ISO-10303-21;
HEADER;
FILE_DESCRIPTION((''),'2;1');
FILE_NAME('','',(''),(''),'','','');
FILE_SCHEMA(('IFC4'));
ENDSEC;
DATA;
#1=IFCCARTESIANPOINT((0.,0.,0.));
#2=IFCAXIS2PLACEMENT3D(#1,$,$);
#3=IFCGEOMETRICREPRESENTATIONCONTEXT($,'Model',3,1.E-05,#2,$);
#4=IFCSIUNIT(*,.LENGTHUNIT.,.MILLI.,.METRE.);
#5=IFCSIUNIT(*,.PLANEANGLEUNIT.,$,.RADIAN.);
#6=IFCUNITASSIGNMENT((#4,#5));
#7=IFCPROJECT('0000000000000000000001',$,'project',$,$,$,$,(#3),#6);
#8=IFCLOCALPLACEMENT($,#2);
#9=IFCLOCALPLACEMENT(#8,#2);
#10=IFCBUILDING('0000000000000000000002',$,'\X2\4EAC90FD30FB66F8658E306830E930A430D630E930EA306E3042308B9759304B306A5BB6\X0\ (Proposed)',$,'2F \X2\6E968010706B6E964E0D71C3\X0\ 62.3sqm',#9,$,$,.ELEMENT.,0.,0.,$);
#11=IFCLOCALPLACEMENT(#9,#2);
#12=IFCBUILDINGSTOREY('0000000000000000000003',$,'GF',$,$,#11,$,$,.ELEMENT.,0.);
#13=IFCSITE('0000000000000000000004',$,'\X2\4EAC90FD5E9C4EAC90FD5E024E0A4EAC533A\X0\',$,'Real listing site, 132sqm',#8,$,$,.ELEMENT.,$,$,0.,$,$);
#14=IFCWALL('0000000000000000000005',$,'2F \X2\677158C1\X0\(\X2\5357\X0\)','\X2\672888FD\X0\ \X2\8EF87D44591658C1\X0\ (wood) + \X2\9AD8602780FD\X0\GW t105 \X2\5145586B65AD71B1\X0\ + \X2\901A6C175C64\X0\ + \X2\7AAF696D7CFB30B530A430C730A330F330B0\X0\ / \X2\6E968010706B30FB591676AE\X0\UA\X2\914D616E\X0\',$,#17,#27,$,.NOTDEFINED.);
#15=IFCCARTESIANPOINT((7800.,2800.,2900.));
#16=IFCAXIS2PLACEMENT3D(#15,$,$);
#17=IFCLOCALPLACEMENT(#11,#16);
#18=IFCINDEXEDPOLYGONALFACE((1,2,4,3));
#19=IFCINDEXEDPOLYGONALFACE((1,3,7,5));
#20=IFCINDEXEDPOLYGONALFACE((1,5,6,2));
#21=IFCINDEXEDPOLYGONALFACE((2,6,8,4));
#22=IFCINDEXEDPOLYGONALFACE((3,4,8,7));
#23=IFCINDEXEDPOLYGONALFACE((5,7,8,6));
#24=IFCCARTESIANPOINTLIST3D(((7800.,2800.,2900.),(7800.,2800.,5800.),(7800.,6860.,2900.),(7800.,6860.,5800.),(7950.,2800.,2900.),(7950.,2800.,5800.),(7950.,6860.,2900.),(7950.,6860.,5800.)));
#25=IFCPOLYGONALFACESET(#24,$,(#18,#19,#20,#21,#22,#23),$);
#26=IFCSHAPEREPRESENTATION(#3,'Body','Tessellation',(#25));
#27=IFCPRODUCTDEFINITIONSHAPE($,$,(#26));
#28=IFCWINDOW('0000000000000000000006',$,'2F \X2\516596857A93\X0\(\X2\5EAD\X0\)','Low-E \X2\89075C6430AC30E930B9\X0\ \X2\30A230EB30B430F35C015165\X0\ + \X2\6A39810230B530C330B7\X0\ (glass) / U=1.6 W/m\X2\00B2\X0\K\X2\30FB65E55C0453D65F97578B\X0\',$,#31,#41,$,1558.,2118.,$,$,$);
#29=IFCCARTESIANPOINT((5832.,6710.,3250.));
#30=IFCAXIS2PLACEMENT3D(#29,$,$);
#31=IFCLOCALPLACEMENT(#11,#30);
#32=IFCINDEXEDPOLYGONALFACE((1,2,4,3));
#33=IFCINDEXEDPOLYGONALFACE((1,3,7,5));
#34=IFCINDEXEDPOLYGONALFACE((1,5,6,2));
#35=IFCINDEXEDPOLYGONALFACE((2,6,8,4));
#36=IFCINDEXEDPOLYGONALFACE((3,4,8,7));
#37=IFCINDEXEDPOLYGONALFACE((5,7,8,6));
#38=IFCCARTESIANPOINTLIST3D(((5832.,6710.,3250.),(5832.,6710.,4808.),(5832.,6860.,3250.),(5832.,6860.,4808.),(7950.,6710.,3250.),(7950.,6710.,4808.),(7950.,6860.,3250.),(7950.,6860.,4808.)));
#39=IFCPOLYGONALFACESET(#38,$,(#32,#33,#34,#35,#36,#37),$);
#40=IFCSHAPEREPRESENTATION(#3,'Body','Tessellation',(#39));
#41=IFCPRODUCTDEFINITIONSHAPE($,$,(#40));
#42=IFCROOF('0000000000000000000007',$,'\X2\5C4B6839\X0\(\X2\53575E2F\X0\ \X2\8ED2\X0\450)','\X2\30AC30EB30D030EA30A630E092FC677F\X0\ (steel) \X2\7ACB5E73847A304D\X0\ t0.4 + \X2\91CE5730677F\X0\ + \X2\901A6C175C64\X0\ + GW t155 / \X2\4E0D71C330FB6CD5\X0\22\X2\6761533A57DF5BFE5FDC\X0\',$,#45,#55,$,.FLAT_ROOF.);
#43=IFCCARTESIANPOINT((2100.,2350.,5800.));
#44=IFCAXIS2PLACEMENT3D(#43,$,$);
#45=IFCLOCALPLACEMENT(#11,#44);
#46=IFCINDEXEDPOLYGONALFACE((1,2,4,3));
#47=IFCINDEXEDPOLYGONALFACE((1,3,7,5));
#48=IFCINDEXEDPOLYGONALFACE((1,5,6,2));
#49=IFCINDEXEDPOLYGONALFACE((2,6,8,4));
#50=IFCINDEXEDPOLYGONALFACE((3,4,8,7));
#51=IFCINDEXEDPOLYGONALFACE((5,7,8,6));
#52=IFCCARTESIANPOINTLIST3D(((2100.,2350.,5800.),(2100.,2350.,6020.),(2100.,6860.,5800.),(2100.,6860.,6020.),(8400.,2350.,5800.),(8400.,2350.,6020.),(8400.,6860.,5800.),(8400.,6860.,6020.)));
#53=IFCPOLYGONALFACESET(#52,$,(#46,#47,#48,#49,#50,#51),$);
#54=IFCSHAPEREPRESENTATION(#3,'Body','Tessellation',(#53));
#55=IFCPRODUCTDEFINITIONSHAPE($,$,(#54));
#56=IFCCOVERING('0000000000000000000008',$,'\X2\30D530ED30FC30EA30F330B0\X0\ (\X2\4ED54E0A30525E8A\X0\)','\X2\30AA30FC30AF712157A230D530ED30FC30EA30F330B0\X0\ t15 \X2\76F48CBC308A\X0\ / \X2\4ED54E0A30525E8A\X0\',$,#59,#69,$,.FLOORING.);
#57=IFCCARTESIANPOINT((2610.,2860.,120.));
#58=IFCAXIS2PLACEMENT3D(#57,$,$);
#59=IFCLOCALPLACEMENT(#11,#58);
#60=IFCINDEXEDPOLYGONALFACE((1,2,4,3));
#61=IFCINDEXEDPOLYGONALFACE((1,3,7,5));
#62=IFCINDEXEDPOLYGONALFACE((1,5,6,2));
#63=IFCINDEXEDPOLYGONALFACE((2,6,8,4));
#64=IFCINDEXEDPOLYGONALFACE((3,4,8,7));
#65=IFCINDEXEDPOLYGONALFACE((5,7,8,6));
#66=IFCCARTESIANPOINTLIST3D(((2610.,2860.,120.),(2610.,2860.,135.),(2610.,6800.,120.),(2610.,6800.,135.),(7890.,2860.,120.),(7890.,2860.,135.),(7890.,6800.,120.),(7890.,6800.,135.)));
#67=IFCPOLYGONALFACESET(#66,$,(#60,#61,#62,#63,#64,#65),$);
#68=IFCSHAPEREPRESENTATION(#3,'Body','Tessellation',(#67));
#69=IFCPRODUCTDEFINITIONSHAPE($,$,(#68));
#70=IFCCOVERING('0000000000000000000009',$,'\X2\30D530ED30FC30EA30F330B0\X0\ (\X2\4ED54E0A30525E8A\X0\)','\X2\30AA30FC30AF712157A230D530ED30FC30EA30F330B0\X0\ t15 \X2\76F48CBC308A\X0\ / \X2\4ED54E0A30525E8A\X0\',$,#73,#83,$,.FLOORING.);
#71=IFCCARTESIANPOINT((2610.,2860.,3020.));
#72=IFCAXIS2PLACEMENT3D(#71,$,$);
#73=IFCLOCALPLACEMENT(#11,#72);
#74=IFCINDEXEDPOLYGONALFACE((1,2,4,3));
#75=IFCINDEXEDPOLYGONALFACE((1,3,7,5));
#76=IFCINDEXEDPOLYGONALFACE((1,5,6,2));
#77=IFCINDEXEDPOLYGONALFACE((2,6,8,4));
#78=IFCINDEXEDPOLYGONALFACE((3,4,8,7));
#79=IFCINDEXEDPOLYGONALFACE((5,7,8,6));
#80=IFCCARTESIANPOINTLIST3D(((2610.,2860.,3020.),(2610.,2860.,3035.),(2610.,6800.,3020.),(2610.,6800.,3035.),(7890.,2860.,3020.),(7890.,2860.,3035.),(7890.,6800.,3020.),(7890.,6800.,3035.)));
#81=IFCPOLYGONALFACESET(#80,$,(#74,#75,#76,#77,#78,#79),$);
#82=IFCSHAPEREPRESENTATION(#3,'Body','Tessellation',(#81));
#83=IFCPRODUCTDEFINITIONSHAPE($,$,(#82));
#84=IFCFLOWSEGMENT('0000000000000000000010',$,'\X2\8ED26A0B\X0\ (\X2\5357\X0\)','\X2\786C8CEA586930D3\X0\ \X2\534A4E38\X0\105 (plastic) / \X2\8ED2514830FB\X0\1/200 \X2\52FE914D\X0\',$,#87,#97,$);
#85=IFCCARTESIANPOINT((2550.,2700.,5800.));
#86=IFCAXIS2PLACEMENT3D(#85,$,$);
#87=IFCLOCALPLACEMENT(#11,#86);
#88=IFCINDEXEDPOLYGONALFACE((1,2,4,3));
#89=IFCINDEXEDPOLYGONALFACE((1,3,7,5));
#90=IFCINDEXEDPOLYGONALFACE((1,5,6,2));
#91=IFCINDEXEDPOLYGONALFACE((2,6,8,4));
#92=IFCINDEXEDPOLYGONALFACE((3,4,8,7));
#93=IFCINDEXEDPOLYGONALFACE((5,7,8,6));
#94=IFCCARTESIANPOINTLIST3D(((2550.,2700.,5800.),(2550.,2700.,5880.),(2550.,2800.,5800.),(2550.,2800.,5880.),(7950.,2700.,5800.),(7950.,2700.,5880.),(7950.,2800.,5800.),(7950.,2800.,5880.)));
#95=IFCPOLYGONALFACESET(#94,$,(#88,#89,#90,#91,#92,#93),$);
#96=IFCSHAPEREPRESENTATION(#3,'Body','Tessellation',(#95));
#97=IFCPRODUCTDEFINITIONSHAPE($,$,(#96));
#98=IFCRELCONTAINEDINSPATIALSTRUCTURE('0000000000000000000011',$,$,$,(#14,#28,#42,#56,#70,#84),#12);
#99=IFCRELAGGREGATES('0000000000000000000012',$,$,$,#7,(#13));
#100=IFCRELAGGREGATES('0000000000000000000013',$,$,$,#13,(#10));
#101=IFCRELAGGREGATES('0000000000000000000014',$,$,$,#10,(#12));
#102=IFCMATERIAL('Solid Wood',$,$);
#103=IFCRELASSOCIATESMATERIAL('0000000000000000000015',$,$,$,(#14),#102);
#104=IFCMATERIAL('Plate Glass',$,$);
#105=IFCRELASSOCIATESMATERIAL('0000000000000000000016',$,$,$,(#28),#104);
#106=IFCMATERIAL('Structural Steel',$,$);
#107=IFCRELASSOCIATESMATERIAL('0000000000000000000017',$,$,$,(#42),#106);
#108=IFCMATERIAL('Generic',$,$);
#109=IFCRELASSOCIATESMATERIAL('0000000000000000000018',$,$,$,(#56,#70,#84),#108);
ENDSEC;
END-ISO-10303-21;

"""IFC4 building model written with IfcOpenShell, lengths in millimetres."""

from ifc_helpers import new_model, si_unit, frame, frame_2d, origin, place, context, project, spatial, rectangle, extrude, material, element, fill, save


model = new_model("IFC4")

# Units and contexts
model_context = context("Model", 3, precision=1e-05, world=origin())
ifc_project = project(units=[si_unit("LENGTHUNIT", "METRE", prefix="MILLI"), si_unit("PLANEANGLEUNIT", "RADIAN")], contexts=[model_context])

# Site, building, storey
site_placement = place(None, origin())
site = spatial("IfcSite", under=ifc_project, at=site_placement, Name="京都府京都市上京区", ObjectType="Real listing site, 132sqm", CompositionType="ELEMENT", RefElevation=0.0)
building_placement = place(site_placement, origin())
building = spatial("IfcBuilding", under=site, at=building_placement, Name="京都・書斎とライブラリのある静かな家 (Proposed)", ObjectType="2F 準耐火準不燃 62.3sqm", CompositionType="ELEMENT", ElevationOfRefHeight=0.0, ElevationOfTerrain=0.0)
storey_placement = place(building_placement, origin())
storey = spatial("IfcBuildingStorey", under=building, at=storey_placement, Name="GF", CompositionType="ELEMENT", Elevation=0.0)

# Shared definitions
ifc_material_1 = material(Name="Solid Wood")

# Wall, opening, window
ifc_material_2 = material(Name="Plate Glass")
wall_1_placement = place(storey_placement, frame((7800.0, 2800.0, 2900.0)))
wall_1 = element("IfcWall", 1, at=wall_1_placement, inside=storey, material=ifc_material_1, Name="2F 東壁(南)", Description="木製 軸組外壁 (wood) + 高性能GW t105 充填断熱 + 通気層 + 窯業系サイディング / 準耐火・外皮UA配慮", PredefinedType="NOTDEFINED", context=model_context, shape_type="SweptSolid", body=[
    extrude(rectangle(XDim=150.0, YDim=4060.0, at=frame_2d((75.0, 2030.0))), frame((7800.0, 2800.0, 2900.0)), (0.0, 0.0, 1.0), 2900.0),
])
opening_1_placement = place(storey_placement, frame((5832.0, 6710.0, 3250.0)))
opening_1 = element("IfcOpeningElement", 2, at=opening_1_placement, cuts=wall_1, PredefinedType="NOTDEFINED", context=model_context, shape_type="SweptSolid", body=[
    extrude(rectangle(XDim=2118.0, YDim=150.0, at=frame_2d((1059.0, 75.0))), frame((5832.0, 6710.0, 3250.0)), (0.0, 0.0, 1.0), 1558.0),
])
window_1_placement = place(storey_placement, frame((5832.0, 6710.0, 3250.0)))
window_1 = element("IfcWindow", 3, at=window_1_placement, inside=storey, material=ifc_material_2, Name="2F 入隅窓(庭)", Description="Low-E 複層ガラス アルゴン封入 + 樹脂サッシ (glass) / U=1.6 W/m²K・日射取得型", OverallHeight=1558.0, OverallWidth=2118.0, context=model_context, shape_type="SweptSolid", body=[
    extrude(rectangle(XDim=2118.0, YDim=150.0, at=frame_2d((1059.0, 75.0))), frame((5832.0, 6710.0, 3250.0)), (0.0, 0.0, 1.0), 1558.0),
])
fill(opening_1, window_1)

# Roof
ifc_material_3 = material(Name="Structural Steel")
for number, where, name in (
    (4, (2100.0, 2350.0, 5800.0), "屋根(南帯 軒450)"),
):
    element("IfcRoof", number, at=place(storey_placement, frame(where)), inside=storey, material=ifc_material_3, Name=name, Description="ガルバリウム鋼板 (steel) 立平葺き t0.4 + 野地板 + 通気層 + GW t155 / 不燃・法22条区域対応", PredefinedType="FLAT_ROOF", context=model_context, shape_type="SweptSolid", body=[
        extrude(rectangle(XDim=6300.0, YDim=4510.0, at=frame_2d((3150.0, 2255.0))), frame((2100.0, 2350.0, 5800.0)), (0.0, 0.0, 1.0), 220.0),
    ])

# Coverings
ifc_material_4 = material(Name="Generic")
covering_1_placement = place(storey_placement, frame((2610.0, 2860.0, 120.0)))
element("IfcCovering", 5, at=covering_1_placement, inside=storey, material=ifc_material_4, Name="フローリング (仕上げ床)", Description="オーク無垢フローリング t15 直貼り / 仕上げ床", PredefinedType="FLOORING", context=model_context, shape_type="SweptSolid", body=[
    extrude(rectangle(XDim=5280.0, YDim=3940.0, at=frame_2d((2640.0, 1970.0))), frame((2610.0, 2860.0, 120.0)), (0.0, 0.0, 1.0), 15.0),
])
covering_2_placement = place(storey_placement, frame((2610.0, 2860.0, 3020.0)))
element("IfcCovering", 6, at=covering_2_placement, inside=storey, material=ifc_material_4, Name="フローリング (仕上げ床)", Description="オーク無垢フローリング t15 直貼り / 仕上げ床", PredefinedType="FLOORING", context=model_context, shape_type="SweptSolid", body=[
    extrude(rectangle(XDim=5280.0, YDim=3940.0, at=frame_2d((2640.0, 1970.0))), frame((2610.0, 2860.0, 3020.0)), (0.0, 0.0, 1.0), 15.0),
])

# Flow segment
flow_segment_placement = place(storey_placement, frame((2550.0, 2700.0, 5800.0)))
element("IfcFlowSegment", 7, at=flow_segment_placement, inside=storey, material=ifc_material_4, Name="軒樋 (南)", Description="硬質塩ビ 半丸105 (plastic) / 軒先・1/200 勾配", context=model_context, shape_type="SweptSolid", body=[
    extrude(rectangle(XDim=5400.0, YDim=100.0, at=frame_2d((2700.0, 50.0))), frame((2550.0, 2700.0, 5800.0)), (0.0, 0.0, 1.0), 80.0),
])

save(model, "model.ifc")
